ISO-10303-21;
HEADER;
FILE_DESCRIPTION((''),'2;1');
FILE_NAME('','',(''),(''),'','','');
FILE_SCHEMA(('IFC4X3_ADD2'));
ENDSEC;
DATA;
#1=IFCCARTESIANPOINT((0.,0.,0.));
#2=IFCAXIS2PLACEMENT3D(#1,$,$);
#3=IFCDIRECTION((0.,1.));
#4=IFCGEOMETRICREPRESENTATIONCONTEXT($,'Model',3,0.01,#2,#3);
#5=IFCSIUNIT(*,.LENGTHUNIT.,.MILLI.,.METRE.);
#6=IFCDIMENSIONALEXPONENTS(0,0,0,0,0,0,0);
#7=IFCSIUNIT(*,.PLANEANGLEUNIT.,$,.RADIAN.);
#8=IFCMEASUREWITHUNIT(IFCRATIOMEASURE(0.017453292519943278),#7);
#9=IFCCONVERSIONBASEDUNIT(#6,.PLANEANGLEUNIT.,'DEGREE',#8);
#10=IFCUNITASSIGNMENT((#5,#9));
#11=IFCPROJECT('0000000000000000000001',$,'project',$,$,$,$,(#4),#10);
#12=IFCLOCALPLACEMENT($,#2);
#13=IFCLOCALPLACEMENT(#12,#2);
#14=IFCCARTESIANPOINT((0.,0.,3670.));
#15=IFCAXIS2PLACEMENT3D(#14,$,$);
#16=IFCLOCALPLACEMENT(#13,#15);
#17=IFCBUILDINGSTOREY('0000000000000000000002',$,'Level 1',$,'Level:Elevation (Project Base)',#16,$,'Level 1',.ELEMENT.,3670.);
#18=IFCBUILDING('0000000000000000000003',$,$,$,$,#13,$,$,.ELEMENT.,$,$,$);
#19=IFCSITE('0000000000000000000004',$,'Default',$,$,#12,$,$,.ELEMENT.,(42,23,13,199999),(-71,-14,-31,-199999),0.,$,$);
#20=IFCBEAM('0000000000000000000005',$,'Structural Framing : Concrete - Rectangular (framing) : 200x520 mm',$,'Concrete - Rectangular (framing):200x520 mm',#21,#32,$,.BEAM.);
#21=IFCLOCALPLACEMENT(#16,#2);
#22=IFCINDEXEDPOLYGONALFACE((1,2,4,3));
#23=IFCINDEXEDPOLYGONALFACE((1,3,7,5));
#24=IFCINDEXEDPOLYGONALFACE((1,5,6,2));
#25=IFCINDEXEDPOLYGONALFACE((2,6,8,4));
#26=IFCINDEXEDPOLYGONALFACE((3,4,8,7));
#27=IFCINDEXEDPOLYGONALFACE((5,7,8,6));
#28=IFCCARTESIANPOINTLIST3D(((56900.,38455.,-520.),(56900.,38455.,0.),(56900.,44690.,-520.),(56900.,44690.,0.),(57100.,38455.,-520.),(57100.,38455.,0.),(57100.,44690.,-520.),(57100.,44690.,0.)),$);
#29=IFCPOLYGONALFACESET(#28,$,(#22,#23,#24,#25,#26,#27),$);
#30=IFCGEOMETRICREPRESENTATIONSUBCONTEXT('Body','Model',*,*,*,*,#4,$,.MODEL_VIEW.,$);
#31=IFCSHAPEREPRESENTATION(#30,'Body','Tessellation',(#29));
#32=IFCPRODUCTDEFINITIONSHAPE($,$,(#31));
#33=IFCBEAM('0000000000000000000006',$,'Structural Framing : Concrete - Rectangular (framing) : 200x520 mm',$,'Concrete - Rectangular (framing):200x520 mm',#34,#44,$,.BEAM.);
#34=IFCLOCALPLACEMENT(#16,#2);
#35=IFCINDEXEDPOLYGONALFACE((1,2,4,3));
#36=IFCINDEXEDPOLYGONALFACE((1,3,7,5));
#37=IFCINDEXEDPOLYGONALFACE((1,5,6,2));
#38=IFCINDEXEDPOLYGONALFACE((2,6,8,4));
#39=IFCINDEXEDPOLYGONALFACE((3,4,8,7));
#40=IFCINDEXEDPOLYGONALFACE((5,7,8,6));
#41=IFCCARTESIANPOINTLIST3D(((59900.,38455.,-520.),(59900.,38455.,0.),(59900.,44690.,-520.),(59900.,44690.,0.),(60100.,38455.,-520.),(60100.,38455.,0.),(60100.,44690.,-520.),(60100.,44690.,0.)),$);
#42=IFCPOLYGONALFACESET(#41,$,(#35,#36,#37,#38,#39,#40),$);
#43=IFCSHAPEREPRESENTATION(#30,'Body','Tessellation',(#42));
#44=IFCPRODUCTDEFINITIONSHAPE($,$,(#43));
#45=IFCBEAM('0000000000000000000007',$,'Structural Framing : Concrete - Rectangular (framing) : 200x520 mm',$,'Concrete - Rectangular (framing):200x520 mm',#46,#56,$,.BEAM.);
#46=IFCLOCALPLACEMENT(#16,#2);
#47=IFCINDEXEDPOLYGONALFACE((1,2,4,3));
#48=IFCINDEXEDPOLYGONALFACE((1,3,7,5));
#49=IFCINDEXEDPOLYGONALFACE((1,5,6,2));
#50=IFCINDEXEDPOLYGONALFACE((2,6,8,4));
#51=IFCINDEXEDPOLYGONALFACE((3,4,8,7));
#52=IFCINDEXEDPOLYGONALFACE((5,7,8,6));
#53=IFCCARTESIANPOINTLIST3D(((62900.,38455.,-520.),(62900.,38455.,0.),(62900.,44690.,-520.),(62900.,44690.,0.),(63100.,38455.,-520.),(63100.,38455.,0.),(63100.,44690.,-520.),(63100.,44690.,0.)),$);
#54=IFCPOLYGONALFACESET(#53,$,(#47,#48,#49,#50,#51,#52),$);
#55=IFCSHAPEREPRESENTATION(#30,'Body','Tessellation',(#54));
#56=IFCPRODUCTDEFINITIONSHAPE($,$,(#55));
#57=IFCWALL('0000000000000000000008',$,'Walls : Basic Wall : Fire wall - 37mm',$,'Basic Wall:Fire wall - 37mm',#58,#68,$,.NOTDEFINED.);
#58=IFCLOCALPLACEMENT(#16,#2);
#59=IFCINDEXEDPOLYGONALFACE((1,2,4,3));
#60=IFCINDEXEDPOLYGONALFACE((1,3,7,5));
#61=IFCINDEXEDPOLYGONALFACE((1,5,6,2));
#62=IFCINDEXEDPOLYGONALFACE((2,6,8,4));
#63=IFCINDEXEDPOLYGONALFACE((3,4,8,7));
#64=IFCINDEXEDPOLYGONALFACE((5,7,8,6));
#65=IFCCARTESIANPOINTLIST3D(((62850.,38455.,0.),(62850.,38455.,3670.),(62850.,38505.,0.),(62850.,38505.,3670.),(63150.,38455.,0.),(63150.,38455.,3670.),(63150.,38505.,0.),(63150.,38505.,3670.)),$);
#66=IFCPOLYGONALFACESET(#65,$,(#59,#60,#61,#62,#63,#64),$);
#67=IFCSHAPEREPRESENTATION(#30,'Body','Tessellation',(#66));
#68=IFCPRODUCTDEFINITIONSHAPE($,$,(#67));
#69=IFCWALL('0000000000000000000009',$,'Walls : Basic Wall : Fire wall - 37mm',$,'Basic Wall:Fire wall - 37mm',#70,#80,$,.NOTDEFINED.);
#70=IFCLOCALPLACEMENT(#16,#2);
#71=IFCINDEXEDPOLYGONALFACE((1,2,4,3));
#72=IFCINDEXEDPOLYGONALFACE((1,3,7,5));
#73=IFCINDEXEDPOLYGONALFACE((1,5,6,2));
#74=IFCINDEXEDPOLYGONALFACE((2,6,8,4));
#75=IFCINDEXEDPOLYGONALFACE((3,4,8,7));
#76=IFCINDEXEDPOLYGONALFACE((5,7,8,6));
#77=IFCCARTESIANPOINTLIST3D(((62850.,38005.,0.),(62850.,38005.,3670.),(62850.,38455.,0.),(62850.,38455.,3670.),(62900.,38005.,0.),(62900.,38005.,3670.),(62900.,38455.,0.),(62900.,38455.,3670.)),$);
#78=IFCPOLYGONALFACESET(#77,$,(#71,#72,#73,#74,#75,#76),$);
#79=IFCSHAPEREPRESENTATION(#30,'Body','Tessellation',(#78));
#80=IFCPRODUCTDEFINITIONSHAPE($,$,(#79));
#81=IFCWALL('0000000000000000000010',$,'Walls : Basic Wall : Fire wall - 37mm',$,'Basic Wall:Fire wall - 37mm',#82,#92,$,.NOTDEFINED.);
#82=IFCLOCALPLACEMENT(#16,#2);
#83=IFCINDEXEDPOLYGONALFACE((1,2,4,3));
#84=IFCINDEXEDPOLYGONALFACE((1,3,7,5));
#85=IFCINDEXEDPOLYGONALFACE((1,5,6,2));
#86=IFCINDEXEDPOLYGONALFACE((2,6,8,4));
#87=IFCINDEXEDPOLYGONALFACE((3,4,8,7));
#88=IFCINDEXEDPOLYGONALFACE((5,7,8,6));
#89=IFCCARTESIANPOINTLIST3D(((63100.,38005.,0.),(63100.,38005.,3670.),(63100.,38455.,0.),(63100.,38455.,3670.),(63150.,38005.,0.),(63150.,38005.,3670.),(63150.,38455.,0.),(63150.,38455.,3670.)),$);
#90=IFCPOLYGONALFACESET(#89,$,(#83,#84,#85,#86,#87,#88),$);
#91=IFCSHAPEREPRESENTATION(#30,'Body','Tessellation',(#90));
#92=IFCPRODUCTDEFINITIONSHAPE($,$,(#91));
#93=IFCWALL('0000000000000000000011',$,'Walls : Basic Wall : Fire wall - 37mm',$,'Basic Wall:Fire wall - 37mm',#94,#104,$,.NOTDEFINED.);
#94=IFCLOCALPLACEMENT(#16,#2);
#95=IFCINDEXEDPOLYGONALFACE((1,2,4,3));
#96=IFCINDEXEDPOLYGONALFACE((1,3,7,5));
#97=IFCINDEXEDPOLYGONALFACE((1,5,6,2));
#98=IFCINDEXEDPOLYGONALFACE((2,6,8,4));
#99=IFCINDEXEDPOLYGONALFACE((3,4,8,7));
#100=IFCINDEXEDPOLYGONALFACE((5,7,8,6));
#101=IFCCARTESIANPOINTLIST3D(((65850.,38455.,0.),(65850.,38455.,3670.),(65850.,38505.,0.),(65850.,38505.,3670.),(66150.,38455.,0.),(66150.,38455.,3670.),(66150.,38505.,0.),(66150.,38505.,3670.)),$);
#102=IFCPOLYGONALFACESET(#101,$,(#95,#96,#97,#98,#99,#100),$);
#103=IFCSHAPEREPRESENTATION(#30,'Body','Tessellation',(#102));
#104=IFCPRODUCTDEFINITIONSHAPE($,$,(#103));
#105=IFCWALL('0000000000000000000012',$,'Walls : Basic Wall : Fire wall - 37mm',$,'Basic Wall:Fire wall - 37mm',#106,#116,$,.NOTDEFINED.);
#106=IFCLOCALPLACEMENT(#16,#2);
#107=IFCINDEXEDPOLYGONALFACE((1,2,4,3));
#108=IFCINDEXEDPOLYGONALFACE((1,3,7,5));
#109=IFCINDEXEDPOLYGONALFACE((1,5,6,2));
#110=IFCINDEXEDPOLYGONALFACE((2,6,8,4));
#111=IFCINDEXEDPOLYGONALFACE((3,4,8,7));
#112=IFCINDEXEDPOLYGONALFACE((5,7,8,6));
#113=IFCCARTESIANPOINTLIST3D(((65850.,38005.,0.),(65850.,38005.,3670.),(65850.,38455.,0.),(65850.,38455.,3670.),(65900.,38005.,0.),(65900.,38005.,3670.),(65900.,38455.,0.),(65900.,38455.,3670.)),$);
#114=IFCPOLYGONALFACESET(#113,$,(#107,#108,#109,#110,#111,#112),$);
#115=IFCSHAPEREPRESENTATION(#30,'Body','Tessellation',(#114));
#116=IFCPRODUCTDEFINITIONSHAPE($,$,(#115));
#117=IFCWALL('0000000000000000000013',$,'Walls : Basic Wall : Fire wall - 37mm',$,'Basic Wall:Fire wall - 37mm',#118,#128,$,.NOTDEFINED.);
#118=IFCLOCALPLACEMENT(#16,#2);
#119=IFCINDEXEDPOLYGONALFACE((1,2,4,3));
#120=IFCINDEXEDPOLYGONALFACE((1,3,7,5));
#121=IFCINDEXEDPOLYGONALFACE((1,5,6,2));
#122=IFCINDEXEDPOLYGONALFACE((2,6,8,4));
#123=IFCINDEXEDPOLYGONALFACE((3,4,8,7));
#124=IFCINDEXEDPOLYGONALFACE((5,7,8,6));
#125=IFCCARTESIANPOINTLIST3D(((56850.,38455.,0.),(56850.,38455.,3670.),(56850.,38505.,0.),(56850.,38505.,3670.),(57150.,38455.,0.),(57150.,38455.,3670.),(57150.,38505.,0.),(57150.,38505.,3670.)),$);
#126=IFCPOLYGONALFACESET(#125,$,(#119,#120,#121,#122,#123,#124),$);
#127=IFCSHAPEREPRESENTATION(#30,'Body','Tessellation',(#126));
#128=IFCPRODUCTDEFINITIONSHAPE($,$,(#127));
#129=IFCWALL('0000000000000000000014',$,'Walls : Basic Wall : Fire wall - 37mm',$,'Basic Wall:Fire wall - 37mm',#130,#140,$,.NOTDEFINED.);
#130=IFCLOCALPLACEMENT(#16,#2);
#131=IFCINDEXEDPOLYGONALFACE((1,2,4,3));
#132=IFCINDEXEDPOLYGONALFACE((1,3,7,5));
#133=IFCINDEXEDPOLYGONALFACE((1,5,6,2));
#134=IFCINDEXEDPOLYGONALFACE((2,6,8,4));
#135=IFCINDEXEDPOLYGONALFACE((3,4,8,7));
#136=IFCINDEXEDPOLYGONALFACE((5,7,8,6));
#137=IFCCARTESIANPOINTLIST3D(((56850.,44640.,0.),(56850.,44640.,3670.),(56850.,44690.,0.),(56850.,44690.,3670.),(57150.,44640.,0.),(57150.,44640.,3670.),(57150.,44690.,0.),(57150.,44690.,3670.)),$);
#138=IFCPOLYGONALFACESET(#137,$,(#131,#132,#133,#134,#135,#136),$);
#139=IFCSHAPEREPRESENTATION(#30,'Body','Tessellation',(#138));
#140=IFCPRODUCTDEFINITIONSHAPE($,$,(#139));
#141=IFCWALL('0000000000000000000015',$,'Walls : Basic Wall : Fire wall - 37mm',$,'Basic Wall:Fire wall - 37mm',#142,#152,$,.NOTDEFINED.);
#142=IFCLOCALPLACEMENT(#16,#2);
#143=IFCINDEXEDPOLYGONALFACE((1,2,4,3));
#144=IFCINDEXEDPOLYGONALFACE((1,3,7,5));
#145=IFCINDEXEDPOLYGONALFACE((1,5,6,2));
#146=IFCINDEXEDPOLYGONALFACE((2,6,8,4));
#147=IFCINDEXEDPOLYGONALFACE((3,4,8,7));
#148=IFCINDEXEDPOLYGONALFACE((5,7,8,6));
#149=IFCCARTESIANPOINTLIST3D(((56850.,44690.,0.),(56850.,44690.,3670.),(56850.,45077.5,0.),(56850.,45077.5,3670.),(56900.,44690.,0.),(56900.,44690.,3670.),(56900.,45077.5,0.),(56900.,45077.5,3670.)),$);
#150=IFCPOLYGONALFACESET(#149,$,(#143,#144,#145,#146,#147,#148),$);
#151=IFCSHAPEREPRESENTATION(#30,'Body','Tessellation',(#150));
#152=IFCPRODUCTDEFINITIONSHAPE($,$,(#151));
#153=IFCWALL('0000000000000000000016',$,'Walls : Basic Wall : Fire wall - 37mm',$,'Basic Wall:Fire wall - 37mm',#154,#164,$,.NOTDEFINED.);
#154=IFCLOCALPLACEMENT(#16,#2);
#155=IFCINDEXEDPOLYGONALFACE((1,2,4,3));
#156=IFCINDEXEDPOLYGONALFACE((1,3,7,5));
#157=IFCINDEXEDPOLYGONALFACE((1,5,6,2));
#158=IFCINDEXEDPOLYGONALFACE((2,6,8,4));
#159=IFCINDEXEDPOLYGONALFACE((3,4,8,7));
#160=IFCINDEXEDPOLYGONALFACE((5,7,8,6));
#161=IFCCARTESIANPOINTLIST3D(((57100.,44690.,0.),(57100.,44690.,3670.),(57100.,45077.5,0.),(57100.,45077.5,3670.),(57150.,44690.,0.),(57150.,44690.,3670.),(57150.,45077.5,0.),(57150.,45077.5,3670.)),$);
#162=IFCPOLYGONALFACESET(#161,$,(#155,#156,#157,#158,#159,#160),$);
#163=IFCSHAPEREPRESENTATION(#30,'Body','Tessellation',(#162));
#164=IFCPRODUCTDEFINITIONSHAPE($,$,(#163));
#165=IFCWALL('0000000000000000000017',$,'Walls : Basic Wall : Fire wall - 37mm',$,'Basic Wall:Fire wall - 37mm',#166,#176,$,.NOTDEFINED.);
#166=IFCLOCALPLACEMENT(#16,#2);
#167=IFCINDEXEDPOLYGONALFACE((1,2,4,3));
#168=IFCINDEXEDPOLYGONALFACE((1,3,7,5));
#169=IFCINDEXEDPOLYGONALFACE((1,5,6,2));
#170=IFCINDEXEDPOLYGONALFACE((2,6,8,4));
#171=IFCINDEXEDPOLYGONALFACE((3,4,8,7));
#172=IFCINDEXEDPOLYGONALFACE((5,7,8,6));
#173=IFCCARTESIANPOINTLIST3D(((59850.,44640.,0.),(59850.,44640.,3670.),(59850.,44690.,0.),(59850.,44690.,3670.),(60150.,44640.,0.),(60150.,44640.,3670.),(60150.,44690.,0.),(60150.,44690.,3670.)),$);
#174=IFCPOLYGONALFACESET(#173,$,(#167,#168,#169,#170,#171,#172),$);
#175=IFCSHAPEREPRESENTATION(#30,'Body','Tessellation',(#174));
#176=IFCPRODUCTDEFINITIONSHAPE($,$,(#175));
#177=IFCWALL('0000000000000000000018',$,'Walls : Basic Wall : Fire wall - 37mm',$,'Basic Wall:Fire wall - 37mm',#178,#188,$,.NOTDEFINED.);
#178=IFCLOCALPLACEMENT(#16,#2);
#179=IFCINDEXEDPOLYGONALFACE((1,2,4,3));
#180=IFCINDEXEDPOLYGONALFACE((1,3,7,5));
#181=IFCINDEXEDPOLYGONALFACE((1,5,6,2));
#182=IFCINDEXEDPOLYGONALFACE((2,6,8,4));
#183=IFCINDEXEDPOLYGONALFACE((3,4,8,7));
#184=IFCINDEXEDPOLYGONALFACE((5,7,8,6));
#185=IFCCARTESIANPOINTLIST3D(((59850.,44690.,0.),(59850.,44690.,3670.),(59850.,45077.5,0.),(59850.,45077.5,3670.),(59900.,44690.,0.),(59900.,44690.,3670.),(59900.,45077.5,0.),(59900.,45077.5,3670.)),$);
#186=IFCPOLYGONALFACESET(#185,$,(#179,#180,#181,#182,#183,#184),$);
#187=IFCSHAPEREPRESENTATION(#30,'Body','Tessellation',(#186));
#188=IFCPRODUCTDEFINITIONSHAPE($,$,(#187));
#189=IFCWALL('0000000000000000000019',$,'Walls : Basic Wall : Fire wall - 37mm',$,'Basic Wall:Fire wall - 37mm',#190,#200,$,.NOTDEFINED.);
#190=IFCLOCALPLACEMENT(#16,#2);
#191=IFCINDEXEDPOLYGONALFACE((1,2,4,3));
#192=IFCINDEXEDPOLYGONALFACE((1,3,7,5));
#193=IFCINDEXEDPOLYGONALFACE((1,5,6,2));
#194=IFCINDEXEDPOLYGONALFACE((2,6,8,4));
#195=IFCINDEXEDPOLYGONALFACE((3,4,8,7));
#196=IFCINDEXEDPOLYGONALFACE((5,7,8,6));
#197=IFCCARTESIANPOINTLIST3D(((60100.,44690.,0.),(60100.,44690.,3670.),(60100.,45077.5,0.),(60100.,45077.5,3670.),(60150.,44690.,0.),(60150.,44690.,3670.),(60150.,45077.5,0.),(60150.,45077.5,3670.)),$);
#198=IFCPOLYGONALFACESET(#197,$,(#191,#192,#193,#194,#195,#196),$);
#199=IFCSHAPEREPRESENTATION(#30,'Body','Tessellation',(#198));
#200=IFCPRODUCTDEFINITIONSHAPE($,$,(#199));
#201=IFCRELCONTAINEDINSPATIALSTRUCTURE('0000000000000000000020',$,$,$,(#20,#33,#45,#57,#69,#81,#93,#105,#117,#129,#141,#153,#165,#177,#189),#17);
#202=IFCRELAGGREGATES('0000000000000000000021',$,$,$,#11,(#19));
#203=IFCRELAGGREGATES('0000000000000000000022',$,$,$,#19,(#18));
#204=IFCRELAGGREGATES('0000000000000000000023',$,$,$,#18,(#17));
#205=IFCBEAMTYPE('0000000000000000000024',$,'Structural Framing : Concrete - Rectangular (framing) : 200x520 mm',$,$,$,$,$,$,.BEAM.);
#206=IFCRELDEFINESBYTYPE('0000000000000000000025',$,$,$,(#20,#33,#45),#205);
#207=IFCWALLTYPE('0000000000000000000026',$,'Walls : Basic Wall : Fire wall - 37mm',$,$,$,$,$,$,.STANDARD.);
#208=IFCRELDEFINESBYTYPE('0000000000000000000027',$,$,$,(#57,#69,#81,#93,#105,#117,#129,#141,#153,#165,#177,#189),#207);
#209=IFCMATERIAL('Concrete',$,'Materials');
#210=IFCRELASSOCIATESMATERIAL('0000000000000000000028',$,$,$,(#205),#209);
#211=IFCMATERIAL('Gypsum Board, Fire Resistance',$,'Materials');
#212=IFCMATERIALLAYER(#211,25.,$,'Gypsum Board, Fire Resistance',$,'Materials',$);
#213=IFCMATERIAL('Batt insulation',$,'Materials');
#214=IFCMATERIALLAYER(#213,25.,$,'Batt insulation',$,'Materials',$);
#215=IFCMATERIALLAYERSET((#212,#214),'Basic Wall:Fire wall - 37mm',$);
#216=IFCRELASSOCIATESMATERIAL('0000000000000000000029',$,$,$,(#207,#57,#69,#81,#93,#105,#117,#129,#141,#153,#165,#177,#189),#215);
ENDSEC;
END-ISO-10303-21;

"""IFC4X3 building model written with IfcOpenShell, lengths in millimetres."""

from ifc_helpers import new_model, entity, si_unit, converted_unit, direction, frame, frame_2d, origin, place, context, subcontext, project, spatial, rectangle, extrude, source, transform, mapped, material, layer, layer_set, material_profile, profile_set, type_object, type_shapes, element, save


model = new_model("IFC4X3")

# Units and contexts
model_context = context("Model", 3, precision=0.01, world=origin(), true_north=direction((0.0, 1.0)))
body_context = subcontext(model_context, "Body", "Model", "MODEL_VIEW")
ifc_project = project(units=[si_unit("LENGTHUNIT", "METRE", prefix="MILLI"), converted_unit("PLANEANGLEUNIT", "DEGREE", entity("IfcRatioMeasure", 0.017453292519943278), si_unit("PLANEANGLEUNIT", "RADIAN"), dimensions=[0, 0, 0, 0, 0, 0, 0])], contexts=[model_context])

# Site, building, storey
site_placement = place(None, origin())
site = spatial("IfcSite", under=ifc_project, at=site_placement, Name="Default", CompositionType="ELEMENT", RefLatitude=(42, 23, 13, 199999), RefLongitude=(-71, -14, -31, -199999), RefElevation=0.0)
building_placement = place(site_placement, origin())
building = spatial("IfcBuilding", under=site, at=building_placement, CompositionType="ELEMENT")
storey_placement = place(building_placement, frame((0.0, 0.0, 3670.0)))
storey = spatial("IfcBuildingStorey", under=building, at=storey_placement, Name="Level 1", ObjectType="Level:Elevation (Project Base)", LongName="Level 1", CompositionType="ELEMENT", Elevation=3670.0)

# Beams
ifc_material_1 = material(Name="Concrete", Category="Materials")
ifc_material_profile = material_profile(ifc_material_1, rectangle(XDim=520.0, YDim=200.0, at=frame_2d((0.0, 0.0), x_axis=(1.0, 0.0))), Name="200x520 mm")
ifc_profile_set = profile_set([ifc_material_profile], Name="200x520 mm")
beam_type = type_object("IfcBeamType", Name="Structural Framing : Concrete - Rectangular (framing) : 200x520 mm", PredefinedType="BEAM", material=ifc_profile_set)
shared_shape = source(origin(), body_context, "Body", "SweptSolid", [
    extrude(rectangle(XDim=520.0, YDim=200.0, at=frame_2d((0.0, 0.0), x_axis=(1.0, 0.0))), frame((-1350.0, 0.0, 0.0), z_axis=(1.0, 0.0, 0.0), x_axis=(0.0, 0.0, -1.0)), (0.0, 0.0, 1.0), 6235.0),
])
type_shapes(beam_type, [shared_shape])
for number, where, z_axis, x_axis, name in (
    (1, (57000.0, 43340.0, -260.0), (0.0, 0.0, 1.0), (0.0, -1.0, 0.0), "Structural Framing : Concrete - Rectangular (framing) : 200x520 mm"),
    (2, (60000.0, 43340.0, -260.0), (0.0, 0.0, 1.0), (0.0, -1.0, 0.0), "Structural Framing : Concrete - Rectangular (framing) : 200x520 mm"),
    (3, (63000.0, 43340.0, -260.0), (0.0, 0.0, 1.0), (0.0, -1.0, 0.0), "Structural Framing : Concrete - Rectangular (framing) : 200x520 mm"),
):
    element("IfcBeam", number, at=place(storey_placement, frame(where, z_axis=z_axis, x_axis=x_axis)), inside=storey, type_object=beam_type, Name=name, ObjectType="Concrete - Rectangular (framing):200x520 mm", PredefinedType="BEAM", context=body_context, shape_type="MappedRepresentation", body=[
        mapped(shared_shape, transform((0.0, 0.0, 0.0), scale=1.0)),
    ])

# Walls
ifc_material_2 = material(Name="Gypsum Board, Fire Resistance", Category="Materials")
ifc_layer_1 = layer(ifc_material_2, 25.0, Name="Gypsum Board, Fire Resistance", Category="Materials")
ifc_material_3 = material(Name="Batt insulation", Category="Materials")
ifc_layer_2 = layer(ifc_material_3, 25.0, Name="Batt insulation", Category="Materials")
ifc_layer_set = layer_set([ifc_layer_1, ifc_layer_2], Name="Basic Wall:Fire wall - 37mm")
wall_type = type_object("IfcWallType", Name="Walls : Basic Wall : Fire wall - 37mm", PredefinedType="STANDARD", material=ifc_layer_set)
wall_1_placement = place(storey_placement, frame((62850.0, 38480.0, 0.0)))
element("IfcWall", 4, at=wall_1_placement, inside=storey, type_object=wall_type, material=ifc_layer_set, Name="Walls : Basic Wall : Fire wall - 37mm", ObjectType="Basic Wall:Fire wall - 37mm", PredefinedType="NOTDEFINED", context=body_context, shape_type="SweptSolid", body=[
    extrude(rectangle(XDim=300.0, YDim=50.0, at=frame_2d((150.0, 0.0), x_axis=(-1.0, 0.0))), origin(), (0.0, 0.0, 1.0), 3670.0),
])
for number, where, z_axis, x_axis, name in (
    (5, (62875.0, 38455.0, 0.0), (0.0, 0.0, 1.0), (0.0, -1.0, 0.0), "Walls : Basic Wall : Fire wall - 37mm"),
    (6, (63125.0, 38455.0, 0.0), (0.0, 0.0, 1.0), (0.0, -1.0, 0.0), "Walls : Basic Wall : Fire wall - 37mm"),
):
    element("IfcWall", number, at=place(storey_placement, frame(where, z_axis=z_axis, x_axis=x_axis)), inside=storey, type_object=wall_type, material=ifc_layer_set, Name=name, ObjectType="Basic Wall:Fire wall - 37mm", PredefinedType="NOTDEFINED", context=body_context, shape_type="SweptSolid", body=[
        extrude(rectangle(XDim=450.0, YDim=50.0, at=frame_2d((225.0, 0.0), x_axis=(-1.0, 0.0))), origin(), (0.0, 0.0, 1.0), 3670.0),
    ])
wall_2_placement = place(storey_placement, frame((65850.0, 38480.0, 0.0)))
element("IfcWall", 7, at=wall_2_placement, inside=storey, type_object=wall_type, material=ifc_layer_set, Name="Walls : Basic Wall : Fire wall - 37mm", ObjectType="Basic Wall:Fire wall - 37mm", PredefinedType="NOTDEFINED", context=body_context, shape_type="SweptSolid", body=[
    extrude(rectangle(XDim=300.0, YDim=50.0, at=frame_2d((150.0, 0.0), x_axis=(-1.0, 0.0))), origin(), (0.0, 0.0, 1.0), 3670.0),
])
wall_3_placement = place(storey_placement, frame((65875.0, 38455.0, 0.0), z_axis=(0.0, 0.0, 1.0), x_axis=(0.0, -1.0, 0.0)))
element("IfcWall", 8, at=wall_3_placement, inside=storey, type_object=wall_type, material=ifc_layer_set, Name="Walls : Basic Wall : Fire wall - 37mm", ObjectType="Basic Wall:Fire wall - 37mm", PredefinedType="NOTDEFINED", context=body_context, shape_type="SweptSolid", body=[
    extrude(rectangle(XDim=450.0, YDim=50.0, at=frame_2d((225.0, 0.0), x_axis=(-1.0, 0.0))), origin(), (0.0, 0.0, 1.0), 3670.0),
])
wall_4_placement = place(storey_placement, frame((56850.0, 38480.0, 0.0)))
element("IfcWall", 9, at=wall_4_placement, inside=storey, type_object=wall_type, material=ifc_layer_set, Name="Walls : Basic Wall : Fire wall - 37mm", ObjectType="Basic Wall:Fire wall - 37mm", PredefinedType="NOTDEFINED", context=body_context, shape_type="SweptSolid", body=[
    extrude(rectangle(XDim=300.0, YDim=50.0, at=frame_2d((150.0, 0.0), x_axis=(-1.0, 0.0))), origin(), (0.0, 0.0, 1.0), 3670.0),
])
wall_5_placement = place(storey_placement, frame((56850.0, 44665.0, 0.0)))
element("IfcWall", 10, at=wall_5_placement, inside=storey, type_object=wall_type, material=ifc_layer_set, Name="Walls : Basic Wall : Fire wall - 37mm", ObjectType="Basic Wall:Fire wall - 37mm", PredefinedType="NOTDEFINED", context=body_context, shape_type="SweptSolid", body=[
    extrude(rectangle(XDim=300.0, YDim=50.0, at=frame_2d((150.0, 0.0), x_axis=(-1.0, 0.0))), origin(), (0.0, 0.0, 1.0), 3670.0),
])
for number, where, z_axis, x_axis, name in (
    (11, (56875.0, 45077.5, 0.0), (0.0, 0.0, 1.0), (0.0, -1.0, 0.0), "Walls : Basic Wall : Fire wall - 37mm"),
    (12, (57125.0, 45077.5, 0.0), (0.0, 0.0, 1.0), (0.0, -1.0, 0.0), "Walls : Basic Wall : Fire wall - 37mm"),
):
    element("IfcWall", number, at=place(storey_placement, frame(where, z_axis=z_axis, x_axis=x_axis)), inside=storey, type_object=wall_type, material=ifc_layer_set, Name=name, ObjectType="Basic Wall:Fire wall - 37mm", PredefinedType="NOTDEFINED", context=body_context, shape_type="SweptSolid", body=[
        extrude(rectangle(XDim=387.5, YDim=50.0, at=frame_2d((193.8, 0.0), x_axis=(-1.0, 0.0))), origin(), (0.0, 0.0, 1.0), 3670.0),
    ])
wall_6_placement = place(storey_placement, frame((59850.0, 44665.0, 0.0)))
element("IfcWall", 13, at=wall_6_placement, inside=storey, type_object=wall_type, material=ifc_layer_set, Name="Walls : Basic Wall : Fire wall - 37mm", ObjectType="Basic Wall:Fire wall - 37mm", PredefinedType="NOTDEFINED", context=body_context, shape_type="SweptSolid", body=[
    extrude(rectangle(XDim=300.0, YDim=50.0, at=frame_2d((150.0, 0.0), x_axis=(-1.0, 0.0))), origin(), (0.0, 0.0, 1.0), 3670.0),
])
for number, where, z_axis, x_axis, name in (
    (14, (59875.0, 45077.5, 0.0), (0.0, 0.0, 1.0), (0.0, -1.0, 0.0), "Walls : Basic Wall : Fire wall - 37mm"),
    (15, (60125.0, 45077.5, 0.0), (0.0, 0.0, 1.0), (0.0, -1.0, 0.0), "Walls : Basic Wall : Fire wall - 37mm"),
):
    element("IfcWall", number, at=place(storey_placement, frame(where, z_axis=z_axis, x_axis=x_axis)), inside=storey, type_object=wall_type, material=ifc_layer_set, Name=name, ObjectType="Basic Wall:Fire wall - 37mm", PredefinedType="NOTDEFINED", context=body_context, shape_type="SweptSolid", body=[
        extrude(rectangle(XDim=387.5, YDim=50.0, at=frame_2d((193.8, 0.0), x_axis=(-1.0, 0.0))), origin(), (0.0, 0.0, 1.0), 3670.0),
    ])

save(model, "model.ifc")
